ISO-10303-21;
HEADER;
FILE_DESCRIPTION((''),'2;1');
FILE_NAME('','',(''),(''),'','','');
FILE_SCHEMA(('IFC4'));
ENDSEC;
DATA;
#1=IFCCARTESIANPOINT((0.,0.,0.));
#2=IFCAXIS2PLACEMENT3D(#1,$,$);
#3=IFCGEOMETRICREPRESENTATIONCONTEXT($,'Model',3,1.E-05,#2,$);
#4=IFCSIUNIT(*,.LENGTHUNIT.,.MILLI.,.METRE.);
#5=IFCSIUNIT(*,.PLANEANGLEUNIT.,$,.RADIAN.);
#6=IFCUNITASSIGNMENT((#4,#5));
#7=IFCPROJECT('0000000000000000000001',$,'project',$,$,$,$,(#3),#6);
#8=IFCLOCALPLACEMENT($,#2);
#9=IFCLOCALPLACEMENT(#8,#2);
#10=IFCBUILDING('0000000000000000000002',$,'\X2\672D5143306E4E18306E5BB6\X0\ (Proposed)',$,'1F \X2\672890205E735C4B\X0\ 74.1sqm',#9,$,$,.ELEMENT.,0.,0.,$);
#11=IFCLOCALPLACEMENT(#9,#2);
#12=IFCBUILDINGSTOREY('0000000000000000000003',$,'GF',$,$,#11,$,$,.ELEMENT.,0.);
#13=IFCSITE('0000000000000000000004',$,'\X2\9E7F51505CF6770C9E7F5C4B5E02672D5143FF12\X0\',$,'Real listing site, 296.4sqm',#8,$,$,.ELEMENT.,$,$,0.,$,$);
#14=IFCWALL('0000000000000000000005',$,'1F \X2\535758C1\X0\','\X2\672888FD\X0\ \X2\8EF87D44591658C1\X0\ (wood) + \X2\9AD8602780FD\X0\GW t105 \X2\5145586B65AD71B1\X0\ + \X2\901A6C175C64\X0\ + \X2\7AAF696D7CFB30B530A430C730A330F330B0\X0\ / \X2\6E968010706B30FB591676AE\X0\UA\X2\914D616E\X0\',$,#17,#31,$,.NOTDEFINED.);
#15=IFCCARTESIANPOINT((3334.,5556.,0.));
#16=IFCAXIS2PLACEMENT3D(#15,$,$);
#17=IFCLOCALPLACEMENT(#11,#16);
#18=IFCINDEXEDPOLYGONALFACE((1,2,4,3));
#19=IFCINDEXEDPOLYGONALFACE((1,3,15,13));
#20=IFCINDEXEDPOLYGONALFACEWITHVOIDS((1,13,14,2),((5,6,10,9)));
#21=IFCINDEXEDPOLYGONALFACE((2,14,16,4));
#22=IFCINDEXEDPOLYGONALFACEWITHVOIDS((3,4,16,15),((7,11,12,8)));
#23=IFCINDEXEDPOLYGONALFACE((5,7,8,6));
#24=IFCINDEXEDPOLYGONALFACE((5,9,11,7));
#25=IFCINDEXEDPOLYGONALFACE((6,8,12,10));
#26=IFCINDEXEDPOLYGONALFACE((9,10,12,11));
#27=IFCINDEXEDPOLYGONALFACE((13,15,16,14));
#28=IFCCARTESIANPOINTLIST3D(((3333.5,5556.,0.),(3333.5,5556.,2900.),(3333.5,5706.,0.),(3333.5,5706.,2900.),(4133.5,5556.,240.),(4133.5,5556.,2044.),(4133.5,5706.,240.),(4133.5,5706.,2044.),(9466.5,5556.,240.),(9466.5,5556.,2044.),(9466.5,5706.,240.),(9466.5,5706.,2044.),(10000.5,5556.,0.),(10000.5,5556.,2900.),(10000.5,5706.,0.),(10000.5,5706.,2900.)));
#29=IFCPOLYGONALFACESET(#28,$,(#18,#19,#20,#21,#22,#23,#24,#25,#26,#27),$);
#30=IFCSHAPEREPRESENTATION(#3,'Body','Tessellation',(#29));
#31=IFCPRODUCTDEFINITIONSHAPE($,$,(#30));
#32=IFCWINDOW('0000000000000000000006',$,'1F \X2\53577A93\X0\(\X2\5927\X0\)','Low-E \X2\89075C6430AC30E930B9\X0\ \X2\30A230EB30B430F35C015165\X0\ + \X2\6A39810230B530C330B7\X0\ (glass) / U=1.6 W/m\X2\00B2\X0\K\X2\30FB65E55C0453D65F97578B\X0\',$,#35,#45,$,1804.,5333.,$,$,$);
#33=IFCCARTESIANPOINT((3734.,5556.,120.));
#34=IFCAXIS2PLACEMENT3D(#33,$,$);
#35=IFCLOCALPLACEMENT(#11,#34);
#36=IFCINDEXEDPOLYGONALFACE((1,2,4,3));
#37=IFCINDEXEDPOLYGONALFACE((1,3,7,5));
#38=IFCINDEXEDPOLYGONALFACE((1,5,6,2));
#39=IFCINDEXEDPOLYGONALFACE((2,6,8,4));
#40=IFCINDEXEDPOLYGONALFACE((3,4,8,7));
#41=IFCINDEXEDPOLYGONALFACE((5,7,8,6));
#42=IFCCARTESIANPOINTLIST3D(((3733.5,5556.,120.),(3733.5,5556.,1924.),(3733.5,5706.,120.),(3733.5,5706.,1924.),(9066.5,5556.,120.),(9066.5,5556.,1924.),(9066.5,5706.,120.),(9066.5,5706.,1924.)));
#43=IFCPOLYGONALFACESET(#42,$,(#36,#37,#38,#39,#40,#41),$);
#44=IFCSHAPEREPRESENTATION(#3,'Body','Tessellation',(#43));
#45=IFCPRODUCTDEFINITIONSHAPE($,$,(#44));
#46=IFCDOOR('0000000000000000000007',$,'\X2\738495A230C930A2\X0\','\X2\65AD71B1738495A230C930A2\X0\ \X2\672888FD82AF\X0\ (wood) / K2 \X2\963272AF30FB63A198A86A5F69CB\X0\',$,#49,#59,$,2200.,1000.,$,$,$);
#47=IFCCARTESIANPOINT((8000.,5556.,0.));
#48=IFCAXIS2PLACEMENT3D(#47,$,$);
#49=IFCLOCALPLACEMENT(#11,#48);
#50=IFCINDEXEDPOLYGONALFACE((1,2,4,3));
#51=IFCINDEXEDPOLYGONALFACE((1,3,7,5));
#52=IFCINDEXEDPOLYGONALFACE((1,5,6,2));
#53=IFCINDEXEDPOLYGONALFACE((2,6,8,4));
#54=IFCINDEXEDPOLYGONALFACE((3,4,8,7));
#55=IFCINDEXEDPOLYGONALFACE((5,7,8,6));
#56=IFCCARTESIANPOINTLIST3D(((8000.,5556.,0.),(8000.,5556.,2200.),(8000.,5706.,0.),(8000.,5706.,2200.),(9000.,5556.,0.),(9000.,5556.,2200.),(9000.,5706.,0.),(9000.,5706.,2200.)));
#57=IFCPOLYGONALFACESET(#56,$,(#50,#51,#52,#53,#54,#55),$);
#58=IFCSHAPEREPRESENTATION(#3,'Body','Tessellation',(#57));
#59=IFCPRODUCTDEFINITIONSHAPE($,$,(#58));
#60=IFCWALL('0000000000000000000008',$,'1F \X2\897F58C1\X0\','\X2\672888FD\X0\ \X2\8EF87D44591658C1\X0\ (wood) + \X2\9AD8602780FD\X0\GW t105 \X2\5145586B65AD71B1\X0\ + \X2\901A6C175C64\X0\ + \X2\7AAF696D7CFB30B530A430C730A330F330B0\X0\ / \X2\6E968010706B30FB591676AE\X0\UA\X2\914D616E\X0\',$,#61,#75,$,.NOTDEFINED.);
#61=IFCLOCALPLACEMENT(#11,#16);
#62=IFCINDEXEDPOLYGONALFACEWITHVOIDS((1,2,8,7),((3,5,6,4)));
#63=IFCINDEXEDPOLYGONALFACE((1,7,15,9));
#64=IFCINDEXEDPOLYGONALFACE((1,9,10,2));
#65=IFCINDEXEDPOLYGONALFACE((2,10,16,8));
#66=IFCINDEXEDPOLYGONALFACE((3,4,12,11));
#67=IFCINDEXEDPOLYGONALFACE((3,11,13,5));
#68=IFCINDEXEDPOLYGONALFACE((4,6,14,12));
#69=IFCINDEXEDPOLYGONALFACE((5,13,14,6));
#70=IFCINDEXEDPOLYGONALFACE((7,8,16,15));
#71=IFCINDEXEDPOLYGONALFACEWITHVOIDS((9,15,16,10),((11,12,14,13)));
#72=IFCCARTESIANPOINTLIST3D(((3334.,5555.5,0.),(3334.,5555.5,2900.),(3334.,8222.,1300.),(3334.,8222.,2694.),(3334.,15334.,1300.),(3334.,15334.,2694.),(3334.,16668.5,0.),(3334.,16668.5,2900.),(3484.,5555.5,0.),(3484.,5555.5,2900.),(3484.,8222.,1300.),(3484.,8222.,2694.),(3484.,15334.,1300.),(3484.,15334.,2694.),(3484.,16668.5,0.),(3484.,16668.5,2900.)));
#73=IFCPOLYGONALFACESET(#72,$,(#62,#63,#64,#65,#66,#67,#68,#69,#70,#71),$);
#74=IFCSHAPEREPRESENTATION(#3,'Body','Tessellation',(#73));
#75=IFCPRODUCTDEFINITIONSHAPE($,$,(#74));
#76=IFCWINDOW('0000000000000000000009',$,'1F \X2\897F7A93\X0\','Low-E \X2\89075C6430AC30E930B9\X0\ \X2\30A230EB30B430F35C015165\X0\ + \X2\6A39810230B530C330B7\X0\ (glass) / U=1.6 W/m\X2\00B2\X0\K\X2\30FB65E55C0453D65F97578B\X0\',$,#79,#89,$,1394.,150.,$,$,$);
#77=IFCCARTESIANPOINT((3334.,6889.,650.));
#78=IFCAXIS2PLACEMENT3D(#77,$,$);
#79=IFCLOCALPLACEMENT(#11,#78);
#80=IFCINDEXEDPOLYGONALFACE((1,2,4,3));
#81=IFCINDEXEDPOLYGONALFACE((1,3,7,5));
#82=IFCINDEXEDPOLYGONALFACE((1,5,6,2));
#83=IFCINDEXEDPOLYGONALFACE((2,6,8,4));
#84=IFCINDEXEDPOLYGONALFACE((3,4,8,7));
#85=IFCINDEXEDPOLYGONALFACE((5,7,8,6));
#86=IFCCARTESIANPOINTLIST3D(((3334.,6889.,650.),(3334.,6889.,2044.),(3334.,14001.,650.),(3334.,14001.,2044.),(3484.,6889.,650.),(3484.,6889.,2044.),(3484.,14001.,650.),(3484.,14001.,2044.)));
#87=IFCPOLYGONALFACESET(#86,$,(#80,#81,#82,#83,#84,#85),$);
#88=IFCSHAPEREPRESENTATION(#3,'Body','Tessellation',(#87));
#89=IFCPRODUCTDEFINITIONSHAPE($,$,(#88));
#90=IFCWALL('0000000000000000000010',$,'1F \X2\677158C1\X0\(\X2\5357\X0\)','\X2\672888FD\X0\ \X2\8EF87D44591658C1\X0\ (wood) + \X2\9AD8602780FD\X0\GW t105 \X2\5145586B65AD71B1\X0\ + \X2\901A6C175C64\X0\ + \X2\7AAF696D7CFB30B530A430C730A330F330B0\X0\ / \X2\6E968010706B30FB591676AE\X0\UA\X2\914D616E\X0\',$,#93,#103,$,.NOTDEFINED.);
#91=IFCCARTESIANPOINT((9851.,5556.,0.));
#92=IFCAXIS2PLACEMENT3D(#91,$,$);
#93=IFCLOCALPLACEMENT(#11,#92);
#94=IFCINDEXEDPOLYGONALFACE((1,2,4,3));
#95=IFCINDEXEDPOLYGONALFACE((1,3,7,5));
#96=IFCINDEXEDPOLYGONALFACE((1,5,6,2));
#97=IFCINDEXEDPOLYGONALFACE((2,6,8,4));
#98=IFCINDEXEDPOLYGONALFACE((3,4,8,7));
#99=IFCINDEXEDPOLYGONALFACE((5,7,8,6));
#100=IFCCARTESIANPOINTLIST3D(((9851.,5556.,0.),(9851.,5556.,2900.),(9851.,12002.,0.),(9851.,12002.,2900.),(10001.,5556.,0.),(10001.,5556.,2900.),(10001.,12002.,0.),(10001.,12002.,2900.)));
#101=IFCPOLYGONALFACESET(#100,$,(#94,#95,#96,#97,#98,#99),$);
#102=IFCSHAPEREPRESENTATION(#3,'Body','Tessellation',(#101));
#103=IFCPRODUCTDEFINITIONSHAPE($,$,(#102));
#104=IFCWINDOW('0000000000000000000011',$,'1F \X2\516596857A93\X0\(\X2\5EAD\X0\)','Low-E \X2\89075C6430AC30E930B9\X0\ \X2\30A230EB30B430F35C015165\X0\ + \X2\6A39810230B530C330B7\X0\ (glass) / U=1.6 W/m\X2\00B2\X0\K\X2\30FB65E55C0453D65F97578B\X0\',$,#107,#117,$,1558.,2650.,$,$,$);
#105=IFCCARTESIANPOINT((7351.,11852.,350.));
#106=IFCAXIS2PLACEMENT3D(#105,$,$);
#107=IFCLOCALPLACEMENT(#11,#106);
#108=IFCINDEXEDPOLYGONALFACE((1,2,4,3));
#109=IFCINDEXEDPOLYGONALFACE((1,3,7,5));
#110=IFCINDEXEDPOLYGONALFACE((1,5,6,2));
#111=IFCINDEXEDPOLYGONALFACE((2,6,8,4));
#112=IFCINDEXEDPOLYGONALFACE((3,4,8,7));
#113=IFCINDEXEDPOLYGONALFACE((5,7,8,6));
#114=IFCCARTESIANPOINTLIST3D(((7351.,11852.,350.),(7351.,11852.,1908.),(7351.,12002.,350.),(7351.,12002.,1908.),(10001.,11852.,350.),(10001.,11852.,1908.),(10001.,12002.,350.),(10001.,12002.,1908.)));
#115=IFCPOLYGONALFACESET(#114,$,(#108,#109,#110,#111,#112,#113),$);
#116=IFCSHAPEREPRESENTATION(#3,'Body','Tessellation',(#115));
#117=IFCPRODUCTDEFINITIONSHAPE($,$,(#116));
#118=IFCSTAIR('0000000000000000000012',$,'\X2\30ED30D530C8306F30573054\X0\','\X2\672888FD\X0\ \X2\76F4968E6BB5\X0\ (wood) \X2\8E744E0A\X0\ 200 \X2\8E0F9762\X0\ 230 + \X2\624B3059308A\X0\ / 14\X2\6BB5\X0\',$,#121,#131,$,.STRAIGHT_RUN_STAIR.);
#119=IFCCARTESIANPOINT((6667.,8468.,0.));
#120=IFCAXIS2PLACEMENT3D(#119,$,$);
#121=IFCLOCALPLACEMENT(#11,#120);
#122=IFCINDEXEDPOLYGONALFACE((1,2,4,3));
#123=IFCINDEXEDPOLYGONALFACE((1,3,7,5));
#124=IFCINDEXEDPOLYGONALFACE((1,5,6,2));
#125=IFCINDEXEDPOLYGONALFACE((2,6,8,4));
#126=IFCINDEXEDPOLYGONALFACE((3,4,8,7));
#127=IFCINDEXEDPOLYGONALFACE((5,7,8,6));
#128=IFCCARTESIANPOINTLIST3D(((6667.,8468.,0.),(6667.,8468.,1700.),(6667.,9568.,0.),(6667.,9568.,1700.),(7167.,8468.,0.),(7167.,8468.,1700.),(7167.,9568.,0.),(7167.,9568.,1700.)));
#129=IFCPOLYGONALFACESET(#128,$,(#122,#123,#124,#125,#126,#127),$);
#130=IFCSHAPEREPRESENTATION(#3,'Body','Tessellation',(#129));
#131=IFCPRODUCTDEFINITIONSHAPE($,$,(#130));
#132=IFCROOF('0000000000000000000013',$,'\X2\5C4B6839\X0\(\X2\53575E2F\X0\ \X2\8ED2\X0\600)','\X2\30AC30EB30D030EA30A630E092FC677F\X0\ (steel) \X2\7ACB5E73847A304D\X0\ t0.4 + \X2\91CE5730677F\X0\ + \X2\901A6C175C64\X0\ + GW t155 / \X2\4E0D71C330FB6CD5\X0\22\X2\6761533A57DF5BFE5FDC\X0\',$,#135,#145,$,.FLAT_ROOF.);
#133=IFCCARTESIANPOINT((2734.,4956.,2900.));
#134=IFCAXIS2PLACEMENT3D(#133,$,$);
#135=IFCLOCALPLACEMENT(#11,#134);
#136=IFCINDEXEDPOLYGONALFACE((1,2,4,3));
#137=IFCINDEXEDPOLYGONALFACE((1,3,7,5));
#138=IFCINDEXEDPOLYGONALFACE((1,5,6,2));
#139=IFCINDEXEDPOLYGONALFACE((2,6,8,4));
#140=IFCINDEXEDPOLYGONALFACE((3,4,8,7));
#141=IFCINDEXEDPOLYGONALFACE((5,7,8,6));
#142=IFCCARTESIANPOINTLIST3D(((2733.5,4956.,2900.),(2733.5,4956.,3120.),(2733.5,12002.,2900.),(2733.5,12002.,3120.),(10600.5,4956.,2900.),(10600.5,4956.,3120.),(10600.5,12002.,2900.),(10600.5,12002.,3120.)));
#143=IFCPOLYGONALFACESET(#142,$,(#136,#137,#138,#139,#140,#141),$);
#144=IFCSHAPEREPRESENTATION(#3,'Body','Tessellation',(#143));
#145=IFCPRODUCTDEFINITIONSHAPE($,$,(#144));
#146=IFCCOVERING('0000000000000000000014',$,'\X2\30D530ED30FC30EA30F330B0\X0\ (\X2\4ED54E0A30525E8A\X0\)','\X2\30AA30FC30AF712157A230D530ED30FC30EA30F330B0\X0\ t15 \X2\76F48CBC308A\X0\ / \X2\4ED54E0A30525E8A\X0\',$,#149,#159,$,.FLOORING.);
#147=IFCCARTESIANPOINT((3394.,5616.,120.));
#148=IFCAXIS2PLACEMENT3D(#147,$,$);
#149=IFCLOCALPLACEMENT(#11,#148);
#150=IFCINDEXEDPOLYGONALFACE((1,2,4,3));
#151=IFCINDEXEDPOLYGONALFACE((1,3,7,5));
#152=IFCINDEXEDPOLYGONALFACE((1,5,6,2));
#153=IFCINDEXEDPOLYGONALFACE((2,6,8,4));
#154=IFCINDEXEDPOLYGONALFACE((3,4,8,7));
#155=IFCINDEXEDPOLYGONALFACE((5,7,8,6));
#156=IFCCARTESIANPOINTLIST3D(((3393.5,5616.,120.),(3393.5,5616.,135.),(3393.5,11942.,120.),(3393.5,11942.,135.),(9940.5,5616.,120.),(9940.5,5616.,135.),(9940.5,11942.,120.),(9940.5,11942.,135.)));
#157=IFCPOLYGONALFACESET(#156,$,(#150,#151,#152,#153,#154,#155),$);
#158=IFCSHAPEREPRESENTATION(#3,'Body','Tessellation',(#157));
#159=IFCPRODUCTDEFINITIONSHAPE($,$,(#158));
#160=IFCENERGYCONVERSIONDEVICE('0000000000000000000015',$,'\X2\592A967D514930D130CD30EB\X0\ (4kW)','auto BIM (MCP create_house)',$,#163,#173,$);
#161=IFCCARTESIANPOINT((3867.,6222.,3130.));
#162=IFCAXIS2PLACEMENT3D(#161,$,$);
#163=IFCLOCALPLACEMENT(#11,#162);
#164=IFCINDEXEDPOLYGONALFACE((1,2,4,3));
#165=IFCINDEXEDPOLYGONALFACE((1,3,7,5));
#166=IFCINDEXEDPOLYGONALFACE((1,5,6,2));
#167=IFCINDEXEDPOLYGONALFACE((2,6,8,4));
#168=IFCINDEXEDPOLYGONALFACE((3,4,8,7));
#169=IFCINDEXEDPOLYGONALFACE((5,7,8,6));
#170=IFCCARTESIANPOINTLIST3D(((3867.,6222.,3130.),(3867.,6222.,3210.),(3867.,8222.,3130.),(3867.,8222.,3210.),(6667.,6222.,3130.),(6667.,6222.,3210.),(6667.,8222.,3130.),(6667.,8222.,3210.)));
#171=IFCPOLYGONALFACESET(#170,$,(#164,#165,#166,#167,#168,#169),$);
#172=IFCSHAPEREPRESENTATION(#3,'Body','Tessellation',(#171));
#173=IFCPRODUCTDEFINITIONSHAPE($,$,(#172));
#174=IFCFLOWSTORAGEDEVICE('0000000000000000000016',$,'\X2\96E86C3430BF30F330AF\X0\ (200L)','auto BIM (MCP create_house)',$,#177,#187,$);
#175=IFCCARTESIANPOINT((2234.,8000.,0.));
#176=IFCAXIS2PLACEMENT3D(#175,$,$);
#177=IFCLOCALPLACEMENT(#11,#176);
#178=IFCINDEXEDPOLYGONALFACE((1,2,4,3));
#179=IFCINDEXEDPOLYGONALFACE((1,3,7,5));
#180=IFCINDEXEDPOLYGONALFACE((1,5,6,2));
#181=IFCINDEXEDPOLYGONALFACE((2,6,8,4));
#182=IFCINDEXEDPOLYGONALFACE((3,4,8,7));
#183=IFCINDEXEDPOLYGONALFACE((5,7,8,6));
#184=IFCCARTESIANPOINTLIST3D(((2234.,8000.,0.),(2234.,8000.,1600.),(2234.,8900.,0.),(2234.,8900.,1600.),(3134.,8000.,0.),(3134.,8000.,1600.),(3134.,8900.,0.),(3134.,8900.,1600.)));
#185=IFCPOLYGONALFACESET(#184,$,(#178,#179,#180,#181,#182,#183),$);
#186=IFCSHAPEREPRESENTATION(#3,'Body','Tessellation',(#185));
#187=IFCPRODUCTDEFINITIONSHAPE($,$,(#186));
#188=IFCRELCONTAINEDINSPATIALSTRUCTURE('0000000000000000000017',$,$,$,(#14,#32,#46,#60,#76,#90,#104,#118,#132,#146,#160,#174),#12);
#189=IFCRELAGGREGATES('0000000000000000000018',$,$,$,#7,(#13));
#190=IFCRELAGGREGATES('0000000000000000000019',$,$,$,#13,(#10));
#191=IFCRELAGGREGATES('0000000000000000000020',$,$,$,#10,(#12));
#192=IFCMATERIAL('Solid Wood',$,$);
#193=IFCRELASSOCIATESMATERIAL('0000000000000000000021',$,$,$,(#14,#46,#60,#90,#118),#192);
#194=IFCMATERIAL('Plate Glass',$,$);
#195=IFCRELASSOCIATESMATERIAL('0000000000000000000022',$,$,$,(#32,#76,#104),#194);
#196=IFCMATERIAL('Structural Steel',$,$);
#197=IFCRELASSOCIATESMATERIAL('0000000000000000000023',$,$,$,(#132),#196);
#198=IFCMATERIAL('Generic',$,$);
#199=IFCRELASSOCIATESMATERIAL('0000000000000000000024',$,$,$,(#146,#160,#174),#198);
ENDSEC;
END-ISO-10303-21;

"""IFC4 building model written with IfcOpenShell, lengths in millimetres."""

from ifc_helpers import new_model, si_unit, frame, frame_2d, origin, place, context, project, spatial, rectangle, extrude, material, element, fill, save


model = new_model("IFC4")

# Units and contexts
model_context = context("Model", 3, precision=1e-05, world=origin())
ifc_project = project(units=[si_unit("LENGTHUNIT", "METRE", prefix="MILLI"), si_unit("PLANEANGLEUNIT", "RADIAN")], contexts=[model_context])

# Site, building, storey
site_placement = place(None, origin())
site = spatial("IfcSite", under=ifc_project, at=site_placement, Name="鹿児島県鹿屋市札元２", ObjectType="Real listing site, 296.4sqm", CompositionType="ELEMENT", RefElevation=0.0)
building_placement = place(site_placement, origin())
building = spatial("IfcBuilding", under=site, at=building_placement, Name="札元の丘の家 (Proposed)", ObjectType="1F 木造平屋 74.1sqm", CompositionType="ELEMENT", ElevationOfRefHeight=0.0, ElevationOfTerrain=0.0)
storey_placement = place(building_placement, origin())
storey = spatial("IfcBuildingStorey", under=building, at=storey_placement, Name="GF", CompositionType="ELEMENT", Elevation=0.0)

# Shared definitions
ifc_material_1 = material(Name="Solid Wood")

# Wall, openings, window, door
wall_1_placement = place(storey_placement, frame((3334.0, 5556.0, 0.0)))
wall_1 = element("IfcWall", 1, at=wall_1_placement, inside=storey, material=ifc_material_1, Name="1F 南壁", Description="木製 軸組外壁 (wood) + 高性能GW t105 充填断熱 + 通気層 + 窯業系サイディング / 準耐火・外皮UA配慮", PredefinedType="NOTDEFINED", context=model_context, shape_type="SweptSolid", body=[
    extrude(rectangle(XDim=6667.0, YDim=150.0, at=frame_2d((3333.0, 75.0))), frame((3334.0, 5556.0, 0.0)), (0.0, 0.0, 1.0), 2900.0),
])
opening_1_placement = place(storey_placement, frame((3734.0, 5556.0, 120.0)))
opening_1 = element("IfcOpeningElement", 2, at=opening_1_placement, cuts=wall_1, PredefinedType="NOTDEFINED", context=model_context, shape_type="SweptSolid", body=[
    extrude(rectangle(XDim=5333.0, YDim=150.0, at=frame_2d((2666.0, 75.0))), frame((3734.0, 5556.0, 120.0)), (0.0, 0.0, 1.0), 1804.0),
])
opening_2_placement = place(storey_placement, frame((8000.0, 5556.0, 0.0)))
opening_2 = element("IfcOpeningElement", 3, at=opening_2_placement, cuts=wall_1, PredefinedType="NOTDEFINED", context=model_context, shape_type="SweptSolid", body=[
    extrude(rectangle(XDim=1000.0, YDim=150.0, at=frame_2d((500.0, 75.0))), frame((8000.0, 5556.0, 0.0)), (0.0, 0.0, 1.0), 2200.0),
])
ifc_material_2 = material(Name="Plate Glass")
window_1_placement = place(storey_placement, frame((3734.0, 5556.0, 120.0)))
window_1 = element("IfcWindow", 4, at=window_1_placement, inside=storey, material=ifc_material_2, Name="1F 南窓(大)", Description="Low-E 複層ガラス アルゴン封入 + 樹脂サッシ (glass) / U=1.6 W/m²K・日射取得型", OverallHeight=1804.0, OverallWidth=5333.0, context=model_context, shape_type="SweptSolid", body=[
    extrude(rectangle(XDim=5333.0, YDim=150.0, at=frame_2d((2666.0, 75.0))), frame((3734.0, 5556.0, 120.0)), (0.0, 0.0, 1.0), 1804.0),
])
fill(opening_1, window_1)
door_1_placement = place(storey_placement, frame((8000.0, 5556.0, 0.0)))
door_1 = element("IfcDoor", 5, at=door_1_placement, inside=storey, material=ifc_material_1, Name="玄関ドア", Description="断熱玄関ドア 木製芯 (wood) / K2 防犯・採風機構", OverallHeight=2200.0, OverallWidth=1000.0, context=model_context, shape_type="SweptSolid", body=[
    extrude(rectangle(XDim=1000.0, YDim=150.0, at=frame_2d((500.0, 75.0))), frame((8000.0, 5556.0, 0.0)), (0.0, 0.0, 1.0), 2200.0),
])
fill(opening_2, door_1)

# Walls, openings, windows
wall_2_placement = place(storey_placement, frame((3334.0, 5556.0, 0.0)))
wall_2 = element("IfcWall", 6, at=wall_2_placement, inside=storey, material=ifc_material_1, Name="1F 西壁", Description="木製 軸組外壁 (wood) + 高性能GW t105 充填断熱 + 通気層 + 窯業系サイディング / 準耐火・外皮UA配慮", PredefinedType="NOTDEFINED", context=model_context, shape_type="SweptSolid", body=[
    extrude(rectangle(XDim=150.0, YDim=11113.0, at=frame_2d((75.0, 5556.0))), frame((3334.0, 5556.0, 0.0)), (0.0, 0.0, 1.0), 2900.0),
])
opening_3_placement = place(storey_placement, frame((3334.0, 6889.0, 650.0)))
opening_3 = element("IfcOpeningElement", 7, at=opening_3_placement, cuts=wall_2, PredefinedType="NOTDEFINED", context=model_context, shape_type="SweptSolid", body=[
    extrude(rectangle(XDim=150.0, YDim=7112.0, at=frame_2d((75.0, 3556.0))), frame((3334.0, 6889.0, 650.0)), (0.0, 0.0, 1.0), 1394.0),
])
window_2_placement = place(storey_placement, frame((3334.0, 6889.0, 650.0)))
window_2 = element("IfcWindow", 8, at=window_2_placement, inside=storey, material=ifc_material_2, Name="1F 西窓", Description="Low-E 複層ガラス アルゴン封入 + 樹脂サッシ (glass) / U=1.6 W/m²K・日射取得型", OverallHeight=1394.0, OverallWidth=150.0, context=model_context, shape_type="SweptSolid", body=[
    extrude(rectangle(XDim=150.0, YDim=7112.0, at=frame_2d((75.0, 3556.0))), frame((3334.0, 6889.0, 650.0)), (0.0, 0.0, 1.0), 1394.0),
])
fill(opening_3, window_2)
wall_3_placement = place(storey_placement, frame((9851.0, 5556.0, 0.0)))
wall_3 = element("IfcWall", 9, at=wall_3_placement, inside=storey, material=ifc_material_1, Name="1F 東壁(南)", Description="木製 軸組外壁 (wood) + 高性能GW t105 充填断熱 + 通気層 + 窯業系サイディング / 準耐火・外皮UA配慮", PredefinedType="NOTDEFINED", context=model_context, shape_type="SweptSolid", body=[
    extrude(rectangle(XDim=150.0, YDim=6446.0, at=frame_2d((75.0, 3223.0))), frame((9851.0, 5556.0, 0.0)), (0.0, 0.0, 1.0), 2900.0),
])
opening_4_placement = place(storey_placement, frame((7351.0, 11852.0, 350.0)))
opening_4 = element("IfcOpeningElement", 10, at=opening_4_placement, cuts=wall_3, PredefinedType="NOTDEFINED", context=model_context, shape_type="SweptSolid", body=[
    extrude(rectangle(XDim=2650.0, YDim=150.0, at=frame_2d((1325.0, 75.0))), frame((7351.0, 11852.0, 350.0)), (0.0, 0.0, 1.0), 1558.0),
])
window_3_placement = place(storey_placement, frame((7351.0, 11852.0, 350.0)))
window_3 = element("IfcWindow", 11, at=window_3_placement, inside=storey, material=ifc_material_2, Name="1F 入隅窓(庭)", Description="Low-E 複層ガラス アルゴン封入 + 樹脂サッシ (glass) / U=1.6 W/m²K・日射取得型", OverallHeight=1558.0, OverallWidth=2650.0, context=model_context, shape_type="SweptSolid", body=[
    extrude(rectangle(XDim=2650.0, YDim=150.0, at=frame_2d((1325.0, 75.0))), frame((7351.0, 11852.0, 350.0)), (0.0, 0.0, 1.0), 1558.0),
])
fill(opening_4, window_3)

# Stair
stair_placement = place(storey_placement, frame((6667.0, 8468.0, 0.0)))
element("IfcStair", 12, at=stair_placement, inside=storey, material=ifc_material_1, Name="ロフトはしご", Description="木製 直階段 (wood) 蹴上 200 踏面 230 + 手すり / 14段", PredefinedType="STRAIGHT_RUN_STAIR", context=model_context, shape_type="SweptSolid", body=[
    extrude(rectangle(XDim=500.0, YDim=1100.0, at=frame_2d((250.0, 550.0))), frame((6667.0, 8468.0, 0.0)), (0.0, 0.0, 1.0), 1700.0),
])

# Roof
ifc_material_3 = material(Name="Structural Steel")
roof_placement = place(storey_placement, frame((2734.0, 4956.0, 2900.0)))
element("IfcRoof", 13, at=roof_placement, inside=storey, material=ifc_material_3, Name="屋根(南帯 軒600)", Description="ガルバリウム鋼板 (steel) 立平葺き t0.4 + 野地板 + 通気層 + GW t155 / 不燃・法22条区域対応", PredefinedType="FLAT_ROOF", context=model_context, shape_type="SweptSolid", body=[
    extrude(rectangle(XDim=7867.0, YDim=7046.0, at=frame_2d((3933.0, 3523.0))), frame((2734.0, 4956.0, 2900.0)), (0.0, 0.0, 1.0), 220.0),
])

# Covering
ifc_material_4 = material(Name="Generic")
covering_placement = place(storey_placement, frame((3394.0, 5616.0, 120.0)))
element("IfcCovering", 14, at=covering_placement, inside=storey, material=ifc_material_4, Name="フローリング (仕上げ床)", Description="オーク無垢フローリング t15 直貼り / 仕上げ床", PredefinedType="FLOORING", context=model_context, shape_type="SweptSolid", body=[
    extrude(rectangle(XDim=6547.0, YDim=6326.0, at=frame_2d((3273.0, 3163.0))), frame((3394.0, 5616.0, 120.0)), (0.0, 0.0, 1.0), 15.0),
])

# Energy conversion device
energy_conversion_device_placement = place(storey_placement, frame((3867.0, 6222.0, 3130.0)))
element("IfcEnergyConversionDevice", 15, at=energy_conversion_device_placement, inside=storey, material=ifc_material_4, Name="太陽光パネル (4kW)", Description="auto BIM (MCP create_house)", context=model_context, shape_type="SweptSolid", body=[
    extrude(rectangle(XDim=2800.0, YDim=2000.0, at=frame_2d((1400.0, 1000.0))), frame((3867.0, 6222.0, 3130.0)), (0.0, 0.0, 1.0), 80.0),
])

# Flow storage device
flow_storage_device_placement = place(storey_placement, frame((2234.0, 8000.0, 0.0)))
element("IfcFlowStorageDevice", 16, at=flow_storage_device_placement, inside=storey, material=ifc_material_4, Name="雨水タンク (200L)", Description="auto BIM (MCP create_house)", context=model_context, shape_type="SweptSolid", body=[
    extrude(rectangle(XDim=900.0, YDim=900.0, at=frame_2d((450.0, 450.0))), frame((2234.0, 8000.0, 0.0)), (0.0, 0.0, 1.0), 1600.0),
])

save(model, "model.ifc")
